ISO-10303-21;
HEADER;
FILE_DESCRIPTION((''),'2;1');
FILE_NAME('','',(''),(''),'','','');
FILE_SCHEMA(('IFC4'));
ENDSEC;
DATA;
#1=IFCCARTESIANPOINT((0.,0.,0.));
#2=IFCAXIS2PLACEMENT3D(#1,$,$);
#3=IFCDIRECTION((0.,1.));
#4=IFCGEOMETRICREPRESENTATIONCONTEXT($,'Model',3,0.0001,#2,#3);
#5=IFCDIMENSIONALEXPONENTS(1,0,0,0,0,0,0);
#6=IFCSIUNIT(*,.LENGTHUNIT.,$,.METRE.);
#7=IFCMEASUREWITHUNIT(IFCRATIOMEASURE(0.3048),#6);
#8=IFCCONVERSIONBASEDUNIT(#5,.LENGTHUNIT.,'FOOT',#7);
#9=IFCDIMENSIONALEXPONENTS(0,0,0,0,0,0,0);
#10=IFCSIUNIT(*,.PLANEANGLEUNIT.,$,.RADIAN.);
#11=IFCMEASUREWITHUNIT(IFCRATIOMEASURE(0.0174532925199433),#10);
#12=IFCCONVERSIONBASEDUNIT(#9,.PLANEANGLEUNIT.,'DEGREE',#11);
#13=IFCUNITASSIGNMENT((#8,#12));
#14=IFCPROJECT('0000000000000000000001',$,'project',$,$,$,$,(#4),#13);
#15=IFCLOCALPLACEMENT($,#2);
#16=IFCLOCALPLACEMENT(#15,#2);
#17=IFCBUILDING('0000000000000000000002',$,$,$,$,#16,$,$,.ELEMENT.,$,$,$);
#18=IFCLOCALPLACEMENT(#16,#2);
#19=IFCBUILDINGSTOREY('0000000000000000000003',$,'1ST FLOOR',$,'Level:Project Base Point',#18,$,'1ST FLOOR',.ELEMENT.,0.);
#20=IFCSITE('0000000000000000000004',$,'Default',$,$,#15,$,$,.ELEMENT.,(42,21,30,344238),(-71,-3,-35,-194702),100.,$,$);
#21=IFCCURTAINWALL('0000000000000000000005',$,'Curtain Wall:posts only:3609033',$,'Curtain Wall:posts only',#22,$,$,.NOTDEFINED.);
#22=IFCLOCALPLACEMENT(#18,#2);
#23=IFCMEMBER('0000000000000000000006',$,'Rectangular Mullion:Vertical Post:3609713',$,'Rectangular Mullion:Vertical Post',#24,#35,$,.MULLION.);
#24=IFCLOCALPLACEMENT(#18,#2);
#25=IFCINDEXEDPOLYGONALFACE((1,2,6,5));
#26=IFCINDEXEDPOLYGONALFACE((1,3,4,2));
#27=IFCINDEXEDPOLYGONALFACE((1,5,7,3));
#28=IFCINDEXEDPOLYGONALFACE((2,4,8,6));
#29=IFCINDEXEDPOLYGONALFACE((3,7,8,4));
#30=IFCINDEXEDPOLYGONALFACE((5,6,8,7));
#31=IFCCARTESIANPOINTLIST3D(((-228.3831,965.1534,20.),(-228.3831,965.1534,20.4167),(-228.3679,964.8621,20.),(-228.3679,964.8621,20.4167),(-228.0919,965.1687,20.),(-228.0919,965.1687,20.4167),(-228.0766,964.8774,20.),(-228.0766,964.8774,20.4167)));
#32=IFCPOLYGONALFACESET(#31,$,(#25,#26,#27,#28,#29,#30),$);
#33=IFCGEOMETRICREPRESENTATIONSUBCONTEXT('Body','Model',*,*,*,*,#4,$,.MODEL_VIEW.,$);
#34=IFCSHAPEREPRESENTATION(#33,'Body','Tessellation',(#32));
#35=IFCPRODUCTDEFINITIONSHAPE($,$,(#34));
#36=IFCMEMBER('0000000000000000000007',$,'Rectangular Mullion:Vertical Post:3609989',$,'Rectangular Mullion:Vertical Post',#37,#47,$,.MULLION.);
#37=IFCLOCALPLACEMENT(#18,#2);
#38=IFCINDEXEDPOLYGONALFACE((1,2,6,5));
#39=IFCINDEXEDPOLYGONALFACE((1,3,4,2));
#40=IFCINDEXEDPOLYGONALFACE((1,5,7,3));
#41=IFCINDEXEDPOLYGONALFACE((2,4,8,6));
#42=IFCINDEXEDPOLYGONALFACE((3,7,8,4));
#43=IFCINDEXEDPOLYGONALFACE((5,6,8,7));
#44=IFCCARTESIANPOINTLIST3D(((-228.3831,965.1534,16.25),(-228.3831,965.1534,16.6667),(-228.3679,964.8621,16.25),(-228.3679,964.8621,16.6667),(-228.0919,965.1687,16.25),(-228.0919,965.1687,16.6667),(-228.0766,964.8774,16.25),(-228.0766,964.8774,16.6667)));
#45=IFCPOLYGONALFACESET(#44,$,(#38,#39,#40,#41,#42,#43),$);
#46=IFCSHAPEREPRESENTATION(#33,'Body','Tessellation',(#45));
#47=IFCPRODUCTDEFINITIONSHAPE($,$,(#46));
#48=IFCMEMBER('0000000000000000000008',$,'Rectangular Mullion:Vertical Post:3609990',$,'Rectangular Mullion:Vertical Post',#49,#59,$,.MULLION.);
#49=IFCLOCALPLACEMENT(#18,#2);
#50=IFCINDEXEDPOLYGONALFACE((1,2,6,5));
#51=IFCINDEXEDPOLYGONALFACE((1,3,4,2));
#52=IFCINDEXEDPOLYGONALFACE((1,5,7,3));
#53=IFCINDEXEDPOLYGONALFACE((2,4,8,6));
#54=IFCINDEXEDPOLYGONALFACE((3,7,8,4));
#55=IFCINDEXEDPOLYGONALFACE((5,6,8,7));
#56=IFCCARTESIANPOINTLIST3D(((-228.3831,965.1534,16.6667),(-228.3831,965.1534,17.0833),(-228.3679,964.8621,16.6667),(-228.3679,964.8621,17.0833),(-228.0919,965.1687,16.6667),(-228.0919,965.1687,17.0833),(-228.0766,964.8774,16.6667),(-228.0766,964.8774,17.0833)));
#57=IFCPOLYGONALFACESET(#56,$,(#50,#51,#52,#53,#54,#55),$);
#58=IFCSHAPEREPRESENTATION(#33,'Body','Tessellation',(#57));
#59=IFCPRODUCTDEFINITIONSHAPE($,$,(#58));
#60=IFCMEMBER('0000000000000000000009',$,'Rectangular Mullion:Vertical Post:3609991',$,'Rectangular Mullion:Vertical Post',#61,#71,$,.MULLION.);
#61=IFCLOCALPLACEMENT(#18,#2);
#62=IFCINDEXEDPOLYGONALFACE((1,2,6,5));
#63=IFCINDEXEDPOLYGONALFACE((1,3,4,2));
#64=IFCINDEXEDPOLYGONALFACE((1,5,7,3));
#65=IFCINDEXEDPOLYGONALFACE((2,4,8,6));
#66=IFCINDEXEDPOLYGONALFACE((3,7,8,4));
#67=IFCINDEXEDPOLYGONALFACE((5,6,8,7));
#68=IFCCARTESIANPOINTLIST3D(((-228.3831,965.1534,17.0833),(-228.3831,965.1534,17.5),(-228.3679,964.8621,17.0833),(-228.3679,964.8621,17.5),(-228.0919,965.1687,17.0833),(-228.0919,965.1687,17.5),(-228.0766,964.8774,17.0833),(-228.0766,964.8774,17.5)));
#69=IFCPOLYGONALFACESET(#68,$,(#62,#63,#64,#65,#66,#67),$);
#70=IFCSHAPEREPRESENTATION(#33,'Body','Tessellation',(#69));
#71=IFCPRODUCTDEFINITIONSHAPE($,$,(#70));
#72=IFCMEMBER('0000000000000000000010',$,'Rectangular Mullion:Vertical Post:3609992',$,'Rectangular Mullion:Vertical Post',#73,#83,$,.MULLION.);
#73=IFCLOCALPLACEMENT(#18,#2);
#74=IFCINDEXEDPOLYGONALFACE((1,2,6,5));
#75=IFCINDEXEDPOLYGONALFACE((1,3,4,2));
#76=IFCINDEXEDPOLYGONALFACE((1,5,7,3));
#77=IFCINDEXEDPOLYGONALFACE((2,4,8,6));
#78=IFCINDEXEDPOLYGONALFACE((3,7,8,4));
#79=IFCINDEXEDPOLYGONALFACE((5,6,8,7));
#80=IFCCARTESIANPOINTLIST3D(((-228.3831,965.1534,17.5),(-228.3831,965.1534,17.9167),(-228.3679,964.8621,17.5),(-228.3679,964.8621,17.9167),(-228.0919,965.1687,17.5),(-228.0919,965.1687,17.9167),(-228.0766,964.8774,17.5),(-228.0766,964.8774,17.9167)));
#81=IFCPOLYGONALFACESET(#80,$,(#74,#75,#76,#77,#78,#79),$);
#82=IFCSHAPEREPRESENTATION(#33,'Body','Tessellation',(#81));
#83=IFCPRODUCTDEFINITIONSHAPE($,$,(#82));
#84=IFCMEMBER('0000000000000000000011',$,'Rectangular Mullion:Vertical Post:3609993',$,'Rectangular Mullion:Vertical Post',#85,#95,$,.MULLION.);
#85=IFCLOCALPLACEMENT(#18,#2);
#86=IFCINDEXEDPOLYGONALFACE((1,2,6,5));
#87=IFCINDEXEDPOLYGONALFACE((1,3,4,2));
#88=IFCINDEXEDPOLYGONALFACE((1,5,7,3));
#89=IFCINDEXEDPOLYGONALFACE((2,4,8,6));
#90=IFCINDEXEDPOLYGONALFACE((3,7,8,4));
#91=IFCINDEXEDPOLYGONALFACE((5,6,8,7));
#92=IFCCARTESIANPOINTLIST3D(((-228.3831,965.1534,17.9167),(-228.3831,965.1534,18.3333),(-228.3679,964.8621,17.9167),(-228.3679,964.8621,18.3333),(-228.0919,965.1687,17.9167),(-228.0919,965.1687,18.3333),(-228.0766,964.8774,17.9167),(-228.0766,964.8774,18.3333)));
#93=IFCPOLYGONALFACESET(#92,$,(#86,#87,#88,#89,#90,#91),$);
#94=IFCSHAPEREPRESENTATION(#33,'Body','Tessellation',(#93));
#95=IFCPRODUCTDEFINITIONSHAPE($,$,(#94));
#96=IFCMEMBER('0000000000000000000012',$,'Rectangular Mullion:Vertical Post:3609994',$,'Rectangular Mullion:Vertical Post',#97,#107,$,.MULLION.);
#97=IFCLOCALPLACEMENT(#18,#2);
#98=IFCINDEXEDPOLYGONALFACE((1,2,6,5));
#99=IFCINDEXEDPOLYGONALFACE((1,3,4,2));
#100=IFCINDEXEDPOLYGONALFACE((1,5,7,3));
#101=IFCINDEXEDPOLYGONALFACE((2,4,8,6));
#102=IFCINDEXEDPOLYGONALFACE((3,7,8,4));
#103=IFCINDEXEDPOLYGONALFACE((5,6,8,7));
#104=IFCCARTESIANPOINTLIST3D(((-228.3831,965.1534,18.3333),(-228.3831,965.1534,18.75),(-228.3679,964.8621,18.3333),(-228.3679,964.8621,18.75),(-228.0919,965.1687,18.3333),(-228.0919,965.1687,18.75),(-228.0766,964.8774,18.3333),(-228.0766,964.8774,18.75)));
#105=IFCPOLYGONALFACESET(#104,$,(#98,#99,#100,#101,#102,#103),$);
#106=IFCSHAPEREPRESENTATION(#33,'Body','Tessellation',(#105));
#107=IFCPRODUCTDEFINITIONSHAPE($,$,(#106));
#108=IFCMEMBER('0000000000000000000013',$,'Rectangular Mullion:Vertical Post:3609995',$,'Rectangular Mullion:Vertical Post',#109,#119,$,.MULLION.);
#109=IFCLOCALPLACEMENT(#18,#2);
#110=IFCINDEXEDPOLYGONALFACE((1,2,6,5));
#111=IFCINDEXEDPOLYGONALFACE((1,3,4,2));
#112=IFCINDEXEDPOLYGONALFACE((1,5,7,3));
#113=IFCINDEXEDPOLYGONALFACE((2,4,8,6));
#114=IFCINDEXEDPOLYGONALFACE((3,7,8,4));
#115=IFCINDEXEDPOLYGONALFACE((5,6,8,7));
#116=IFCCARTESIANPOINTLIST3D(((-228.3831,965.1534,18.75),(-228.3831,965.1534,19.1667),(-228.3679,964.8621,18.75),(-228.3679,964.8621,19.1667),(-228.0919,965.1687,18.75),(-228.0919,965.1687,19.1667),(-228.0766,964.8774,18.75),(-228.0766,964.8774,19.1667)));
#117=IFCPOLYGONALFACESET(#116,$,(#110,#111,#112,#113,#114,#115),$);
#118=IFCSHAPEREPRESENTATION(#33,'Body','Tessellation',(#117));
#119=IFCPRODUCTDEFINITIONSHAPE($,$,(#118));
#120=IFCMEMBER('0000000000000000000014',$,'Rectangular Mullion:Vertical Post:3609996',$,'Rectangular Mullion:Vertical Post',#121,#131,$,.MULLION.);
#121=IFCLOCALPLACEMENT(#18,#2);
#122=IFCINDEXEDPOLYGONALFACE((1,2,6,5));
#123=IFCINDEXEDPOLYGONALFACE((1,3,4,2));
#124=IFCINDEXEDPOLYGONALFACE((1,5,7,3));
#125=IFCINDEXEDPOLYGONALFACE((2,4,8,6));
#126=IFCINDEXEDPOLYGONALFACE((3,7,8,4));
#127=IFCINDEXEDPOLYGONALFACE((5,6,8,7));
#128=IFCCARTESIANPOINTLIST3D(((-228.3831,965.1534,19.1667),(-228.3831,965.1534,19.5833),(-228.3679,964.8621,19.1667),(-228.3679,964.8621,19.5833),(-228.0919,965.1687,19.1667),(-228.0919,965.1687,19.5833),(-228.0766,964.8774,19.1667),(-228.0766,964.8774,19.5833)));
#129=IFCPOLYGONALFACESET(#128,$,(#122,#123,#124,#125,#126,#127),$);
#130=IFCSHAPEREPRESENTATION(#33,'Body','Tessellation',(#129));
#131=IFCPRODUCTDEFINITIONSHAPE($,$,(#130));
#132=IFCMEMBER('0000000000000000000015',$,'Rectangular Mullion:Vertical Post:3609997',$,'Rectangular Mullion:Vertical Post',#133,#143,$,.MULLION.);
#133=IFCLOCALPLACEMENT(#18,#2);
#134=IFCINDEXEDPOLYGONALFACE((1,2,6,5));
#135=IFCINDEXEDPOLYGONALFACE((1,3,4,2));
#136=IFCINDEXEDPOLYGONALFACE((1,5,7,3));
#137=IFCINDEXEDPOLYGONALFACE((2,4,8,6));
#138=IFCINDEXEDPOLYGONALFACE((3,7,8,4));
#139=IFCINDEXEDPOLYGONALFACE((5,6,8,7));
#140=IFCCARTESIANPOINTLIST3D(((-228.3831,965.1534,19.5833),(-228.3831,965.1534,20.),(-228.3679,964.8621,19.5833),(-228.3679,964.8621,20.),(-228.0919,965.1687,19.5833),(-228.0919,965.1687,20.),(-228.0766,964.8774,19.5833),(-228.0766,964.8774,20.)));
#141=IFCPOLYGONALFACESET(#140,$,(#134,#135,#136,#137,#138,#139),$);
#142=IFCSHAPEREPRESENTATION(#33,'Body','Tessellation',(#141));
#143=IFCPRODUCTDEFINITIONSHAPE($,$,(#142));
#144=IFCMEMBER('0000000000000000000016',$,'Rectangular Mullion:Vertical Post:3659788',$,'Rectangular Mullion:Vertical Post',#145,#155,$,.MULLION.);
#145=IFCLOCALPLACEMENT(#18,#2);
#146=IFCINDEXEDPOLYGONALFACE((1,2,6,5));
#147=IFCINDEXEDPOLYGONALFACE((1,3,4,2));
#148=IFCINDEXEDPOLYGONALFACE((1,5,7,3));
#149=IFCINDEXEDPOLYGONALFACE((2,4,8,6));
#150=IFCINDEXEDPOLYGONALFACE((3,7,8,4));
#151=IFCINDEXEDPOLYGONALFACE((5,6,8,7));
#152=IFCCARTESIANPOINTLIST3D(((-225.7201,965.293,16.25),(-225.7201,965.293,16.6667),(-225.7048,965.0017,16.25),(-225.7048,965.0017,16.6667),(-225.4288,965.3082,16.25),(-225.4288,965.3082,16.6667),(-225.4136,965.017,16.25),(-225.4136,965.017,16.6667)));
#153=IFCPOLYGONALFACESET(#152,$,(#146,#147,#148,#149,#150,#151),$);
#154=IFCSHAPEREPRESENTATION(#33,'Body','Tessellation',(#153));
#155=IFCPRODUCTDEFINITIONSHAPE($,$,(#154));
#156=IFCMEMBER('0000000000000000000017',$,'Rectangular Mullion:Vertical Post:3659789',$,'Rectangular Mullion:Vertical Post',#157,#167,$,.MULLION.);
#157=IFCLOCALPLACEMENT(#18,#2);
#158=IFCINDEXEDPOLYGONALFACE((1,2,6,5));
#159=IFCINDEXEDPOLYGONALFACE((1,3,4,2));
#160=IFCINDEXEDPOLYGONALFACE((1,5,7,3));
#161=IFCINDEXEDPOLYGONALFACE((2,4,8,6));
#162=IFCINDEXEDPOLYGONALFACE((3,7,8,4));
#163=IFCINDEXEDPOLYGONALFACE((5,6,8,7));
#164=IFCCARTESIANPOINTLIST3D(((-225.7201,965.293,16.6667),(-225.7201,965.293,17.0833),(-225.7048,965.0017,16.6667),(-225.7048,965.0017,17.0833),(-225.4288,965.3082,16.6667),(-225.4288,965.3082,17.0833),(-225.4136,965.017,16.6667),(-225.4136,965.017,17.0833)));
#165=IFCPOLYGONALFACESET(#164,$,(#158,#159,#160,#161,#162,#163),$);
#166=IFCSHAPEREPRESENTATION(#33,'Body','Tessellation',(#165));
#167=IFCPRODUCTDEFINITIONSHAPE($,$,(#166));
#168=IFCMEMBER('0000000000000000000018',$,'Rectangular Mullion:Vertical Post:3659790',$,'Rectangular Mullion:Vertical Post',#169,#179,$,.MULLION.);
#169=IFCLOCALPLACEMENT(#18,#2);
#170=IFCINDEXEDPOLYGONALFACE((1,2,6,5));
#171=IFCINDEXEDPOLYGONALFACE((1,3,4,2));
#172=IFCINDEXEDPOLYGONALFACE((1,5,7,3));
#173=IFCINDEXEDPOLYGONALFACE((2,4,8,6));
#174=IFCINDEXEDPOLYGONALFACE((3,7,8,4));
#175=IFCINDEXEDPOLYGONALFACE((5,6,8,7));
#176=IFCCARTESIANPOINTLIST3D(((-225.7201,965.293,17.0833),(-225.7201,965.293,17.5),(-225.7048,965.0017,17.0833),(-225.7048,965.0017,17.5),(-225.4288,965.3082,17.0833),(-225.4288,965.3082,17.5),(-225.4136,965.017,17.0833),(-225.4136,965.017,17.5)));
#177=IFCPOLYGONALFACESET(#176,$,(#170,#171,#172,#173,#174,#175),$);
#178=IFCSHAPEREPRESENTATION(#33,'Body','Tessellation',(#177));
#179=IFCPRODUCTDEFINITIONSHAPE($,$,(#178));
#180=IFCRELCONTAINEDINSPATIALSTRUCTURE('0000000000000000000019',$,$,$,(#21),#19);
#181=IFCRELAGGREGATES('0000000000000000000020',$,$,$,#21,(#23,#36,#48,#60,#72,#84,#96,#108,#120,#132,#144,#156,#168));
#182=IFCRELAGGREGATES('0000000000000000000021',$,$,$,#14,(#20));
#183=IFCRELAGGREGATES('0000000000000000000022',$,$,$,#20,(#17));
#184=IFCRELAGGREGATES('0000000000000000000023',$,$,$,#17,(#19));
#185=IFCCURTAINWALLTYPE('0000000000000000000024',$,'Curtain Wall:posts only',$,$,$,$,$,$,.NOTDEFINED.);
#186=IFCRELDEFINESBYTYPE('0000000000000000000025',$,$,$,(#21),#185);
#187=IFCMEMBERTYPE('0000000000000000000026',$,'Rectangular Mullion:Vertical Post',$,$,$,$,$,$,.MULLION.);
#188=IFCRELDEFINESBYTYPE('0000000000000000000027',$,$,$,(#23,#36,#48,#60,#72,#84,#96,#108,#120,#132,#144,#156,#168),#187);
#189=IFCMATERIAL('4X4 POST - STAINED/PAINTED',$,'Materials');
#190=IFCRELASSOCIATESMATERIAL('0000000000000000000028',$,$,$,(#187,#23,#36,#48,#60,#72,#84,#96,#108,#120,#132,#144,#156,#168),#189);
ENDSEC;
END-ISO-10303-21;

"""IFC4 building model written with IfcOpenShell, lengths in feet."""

from ifc_helpers import new_model, entity, si_unit, converted_unit, direction, frame, origin, origin_2d_with_axis, place, context, subcontext, project, spatial, rectangle, extrude, source, transform, mapped, material, material_profile, profile_set, profile_usage, type_object, type_shapes, element, aggregate, save


model = new_model("IFC4")

# Units and contexts
model_context = context("Model", 3, precision=0.0001, world=origin(), true_north=direction((0.0, 1.0)))
body_context = subcontext(model_context, "Body", "Model", "MODEL_VIEW")
ifc_project = project(units=[converted_unit("LENGTHUNIT", "FOOT", entity("IfcRatioMeasure", 0.3048), si_unit("LENGTHUNIT", "METRE"), dimensions=[1, 0, 0, 0, 0, 0, 0]), converted_unit("PLANEANGLEUNIT", "DEGREE", entity("IfcRatioMeasure", 0.0174532925199433), si_unit("PLANEANGLEUNIT", "RADIAN"), dimensions=[0, 0, 0, 0, 0, 0, 0])], contexts=[model_context])

# Site, building, storey
site_placement = place(None, origin())
site = spatial("IfcSite", under=ifc_project, at=site_placement, Name="Default", CompositionType="ELEMENT", RefLatitude=(42, 21, 30, 344238), RefLongitude=(-71, -3, -35, -194702), RefElevation=100.0)
building_placement = place(site_placement, origin())
building = spatial("IfcBuilding", under=site, at=building_placement, CompositionType="ELEMENT")
storey_placement = place(building_placement, origin())
storey = spatial("IfcBuildingStorey", under=building, at=storey_placement, Name="1ST FLOOR", ObjectType="Level:Project Base Point", LongName="1ST FLOOR", CompositionType="ELEMENT", Elevation=0.0)

# Curtain wall, members
curtain_wall_type_1 = type_object("IfcCurtainWallType", Name="Curtain Wall:posts only", PredefinedType="NOTDEFINED")
curtain_wall_1_placement = place(storey_placement, origin())
curtain_wall_1 = element("IfcCurtainWall", 1, at=curtain_wall_1_placement, inside=storey, type_object=curtain_wall_type_1, Name="Curtain Wall:posts only:3609033", ObjectType="Curtain Wall:posts only", PredefinedType="NOTDEFINED")
ifc_material_1 = material(Name="4X4 POST - STAINED/PAINTED", Category="Materials")
ifc_material_profile_1 = material_profile(ifc_material_1, rectangle(XDim=0.2917, YDim=0.2917, at=origin_2d_with_axis()), Name="Vertical Post")
ifc_profile_set_1 = profile_set([ifc_material_profile_1], Name="Vertical Post")
ifc_profile_usage_1 = profile_usage(ifc_profile_set_1)
member_type_1 = type_object("IfcMemberType", Name="Rectangular Mullion:Vertical Post", PredefinedType="MULLION", material=ifc_profile_set_1)
shared_shape_1 = source(origin(), body_context, "Body", "SweptSolid", [
    extrude(rectangle(XDim=0.2917, YDim=0.2917, at=origin_2d_with_axis()), frame((0.0, -0.2083, -0.4167), z_axis=(0.0, 0.0, 1.0), x_axis=(0.0, -1.0, 0.0)), (0.0, 0.0, 1.0), 0.4167),
])
type_shapes(member_type_1, [shared_shape_1])
member_1_placement = place(storey_placement, frame((-228.2408, 965.2235, 20.0), z_axis=(0.0, 0.0, -1.0), x_axis=(-0.99863, -0.052336, 0.0)))
member_1 = element("IfcMember", 2, at=member_1_placement, type_object=member_type_1, material=ifc_profile_usage_1, Name="Rectangular Mullion:Vertical Post:3609713", ObjectType="Rectangular Mullion:Vertical Post", PredefinedType="MULLION", context=body_context, shape_type="MappedRepresentation", body=[
    mapped(shared_shape_1, transform((0.0, 0.0, 0.0), scale=1.0)),
])
ifc_profile_usage_2 = profile_usage(ifc_profile_set_1)
member_2_placement = place(storey_placement, frame((-228.2408, 965.2235, 16.25), z_axis=(0.0, 0.0, -1.0), x_axis=(-0.99863, -0.052336, 0.0)))
member_2 = element("IfcMember", 3, at=member_2_placement, type_object=member_type_1, material=ifc_profile_usage_2, Name="Rectangular Mullion:Vertical Post:3609989", ObjectType="Rectangular Mullion:Vertical Post", PredefinedType="MULLION", context=body_context, shape_type="MappedRepresentation", body=[
    mapped(shared_shape_1, transform((0.0, 0.0, 0.0), scale=1.0)),
])
ifc_profile_usage_3 = profile_usage(ifc_profile_set_1)
member_3_placement = place(storey_placement, frame((-228.2408, 965.2235, 16.6667), z_axis=(0.0, 0.0, -1.0), x_axis=(-0.99863, -0.052336, 0.0)))
member_3 = element("IfcMember", 4, at=member_3_placement, type_object=member_type_1, material=ifc_profile_usage_3, Name="Rectangular Mullion:Vertical Post:3609990", ObjectType="Rectangular Mullion:Vertical Post", PredefinedType="MULLION", context=body_context, shape_type="MappedRepresentation", body=[
    mapped(shared_shape_1, transform((0.0, 0.0, 0.0), scale=1.0)),
])
ifc_profile_usage_4 = profile_usage(ifc_profile_set_1)
member_4_placement = place(storey_placement, frame((-228.2408, 965.2235, 17.0833), z_axis=(0.0, 0.0, -1.0), x_axis=(-0.99863, -0.052336, 0.0)))
member_4 = element("IfcMember", 5, at=member_4_placement, type_object=member_type_1, material=ifc_profile_usage_4, Name="Rectangular Mullion:Vertical Post:3609991", ObjectType="Rectangular Mullion:Vertical Post", PredefinedType="MULLION", context=body_context, shape_type="MappedRepresentation", body=[
    mapped(shared_shape_1, transform((0.0, 0.0, 0.0), scale=1.0)),
])
ifc_profile_usage_5 = profile_usage(ifc_profile_set_1)
member_5_placement = place(storey_placement, frame((-228.2408, 965.2235, 17.5), z_axis=(0.0, 0.0, -1.0), x_axis=(-0.99863, -0.052336, 0.0)))
member_5 = element("IfcMember", 6, at=member_5_placement, type_object=member_type_1, material=ifc_profile_usage_5, Name="Rectangular Mullion:Vertical Post:3609992", ObjectType="Rectangular Mullion:Vertical Post", PredefinedType="MULLION", context=body_context, shape_type="MappedRepresentation", body=[
    mapped(shared_shape_1, transform((0.0, 0.0, 0.0), scale=1.0)),
])
ifc_profile_usage_6 = profile_usage(ifc_profile_set_1)
member_6_placement = place(storey_placement, frame((-228.2408, 965.2235, 17.9167), z_axis=(0.0, 0.0, -1.0), x_axis=(-0.99863, -0.052336, 0.0)))
member_6 = element("IfcMember", 7, at=member_6_placement, type_object=member_type_1, material=ifc_profile_usage_6, Name="Rectangular Mullion:Vertical Post:3609993", ObjectType="Rectangular Mullion:Vertical Post", PredefinedType="MULLION", context=body_context, shape_type="MappedRepresentation", body=[
    mapped(shared_shape_1, transform((0.0, 0.0, 0.0), scale=1.0)),
])
ifc_profile_usage_7 = profile_usage(ifc_profile_set_1)
member_7_placement = place(storey_placement, frame((-228.2408, 965.2235, 18.3333), z_axis=(0.0, 0.0, -1.0), x_axis=(-0.99863, -0.052336, 0.0)))
member_7 = element("IfcMember", 8, at=member_7_placement, type_object=member_type_1, material=ifc_profile_usage_7, Name="Rectangular Mullion:Vertical Post:3609994", ObjectType="Rectangular Mullion:Vertical Post", PredefinedType="MULLION", context=body_context, shape_type="MappedRepresentation", body=[
    mapped(shared_shape_1, transform((0.0, 0.0, 0.0), scale=1.0)),
])
ifc_profile_usage_8 = profile_usage(ifc_profile_set_1)
member_8_placement = place(storey_placement, frame((-228.2408, 965.2235, 18.75), z_axis=(0.0, 0.0, -1.0), x_axis=(-0.99863, -0.052336, 0.0)))
member_8 = element("IfcMember", 9, at=member_8_placement, type_object=member_type_1, material=ifc_profile_usage_8, Name="Rectangular Mullion:Vertical Post:3609995", ObjectType="Rectangular Mullion:Vertical Post", PredefinedType="MULLION", context=body_context, shape_type="MappedRepresentation", body=[
    mapped(shared_shape_1, transform((0.0, 0.0, 0.0), scale=1.0)),
])
ifc_profile_usage_9 = profile_usage(ifc_profile_set_1)
member_9_placement = place(storey_placement, frame((-228.2408, 965.2235, 19.1667), z_axis=(0.0, 0.0, -1.0), x_axis=(-0.99863, -0.052336, 0.0)))
member_9 = element("IfcMember", 10, at=member_9_placement, type_object=member_type_1, material=ifc_profile_usage_9, Name="Rectangular Mullion:Vertical Post:3609996", ObjectType="Rectangular Mullion:Vertical Post", PredefinedType="MULLION", context=body_context, shape_type="MappedRepresentation", body=[
    mapped(shared_shape_1, transform((0.0, 0.0, 0.0), scale=1.0)),
])
ifc_profile_usage_10 = profile_usage(ifc_profile_set_1)
member_10_placement = place(storey_placement, frame((-228.2408, 965.2235, 19.5833), z_axis=(0.0, 0.0, -1.0), x_axis=(-0.99863, -0.052336, 0.0)))
member_10 = element("IfcMember", 11, at=member_10_placement, type_object=member_type_1, material=ifc_profile_usage_10, Name="Rectangular Mullion:Vertical Post:3609997", ObjectType="Rectangular Mullion:Vertical Post", PredefinedType="MULLION", context=body_context, shape_type="MappedRepresentation", body=[
    mapped(shared_shape_1, transform((0.0, 0.0, 0.0), scale=1.0)),
])
ifc_profile_usage_11 = profile_usage(ifc_profile_set_1)
member_11_placement = place(storey_placement, frame((-225.5777, 965.363, 16.25), z_axis=(0.0, 0.0, -1.0), x_axis=(-0.99863, -0.052336, 0.0)))
member_11 = element("IfcMember", 12, at=member_11_placement, type_object=member_type_1, material=ifc_profile_usage_11, Name="Rectangular Mullion:Vertical Post:3659788", ObjectType="Rectangular Mullion:Vertical Post", PredefinedType="MULLION", context=body_context, shape_type="MappedRepresentation", body=[
    mapped(shared_shape_1, transform((0.0, 0.0, 0.0), scale=1.0)),
])
ifc_profile_usage_12 = profile_usage(ifc_profile_set_1)
member_12_placement = place(storey_placement, frame((-225.5777, 965.363, 16.6667), z_axis=(0.0, 0.0, -1.0), x_axis=(-0.99863, -0.052336, 0.0)))
member_12 = element("IfcMember", 13, at=member_12_placement, type_object=member_type_1, material=ifc_profile_usage_12, Name="Rectangular Mullion:Vertical Post:3659789", ObjectType="Rectangular Mullion:Vertical Post", PredefinedType="MULLION", context=body_context, shape_type="MappedRepresentation", body=[
    mapped(shared_shape_1, transform((0.0, 0.0, 0.0), scale=1.0)),
])
ifc_profile_usage_13 = profile_usage(ifc_profile_set_1)
member_13_placement = place(storey_placement, frame((-225.5777, 965.363, 17.0833), z_axis=(0.0, 0.0, -1.0), x_axis=(-0.99863, -0.052336, 0.0)))
member_13 = element("IfcMember", 14, at=member_13_placement, type_object=member_type_1, material=ifc_profile_usage_13, Name="Rectangular Mullion:Vertical Post:3659790", ObjectType="Rectangular Mullion:Vertical Post", PredefinedType="MULLION", context=body_context, shape_type="MappedRepresentation", body=[
    mapped(shared_shape_1, transform((0.0, 0.0, 0.0), scale=1.0)),
])
aggregate(curtain_wall_1, [member_1, member_2, member_3, member_4, member_5, member_6, member_7, member_8, member_9, member_10, member_11, member_12, member_13])

save(model, "model.ifc")
